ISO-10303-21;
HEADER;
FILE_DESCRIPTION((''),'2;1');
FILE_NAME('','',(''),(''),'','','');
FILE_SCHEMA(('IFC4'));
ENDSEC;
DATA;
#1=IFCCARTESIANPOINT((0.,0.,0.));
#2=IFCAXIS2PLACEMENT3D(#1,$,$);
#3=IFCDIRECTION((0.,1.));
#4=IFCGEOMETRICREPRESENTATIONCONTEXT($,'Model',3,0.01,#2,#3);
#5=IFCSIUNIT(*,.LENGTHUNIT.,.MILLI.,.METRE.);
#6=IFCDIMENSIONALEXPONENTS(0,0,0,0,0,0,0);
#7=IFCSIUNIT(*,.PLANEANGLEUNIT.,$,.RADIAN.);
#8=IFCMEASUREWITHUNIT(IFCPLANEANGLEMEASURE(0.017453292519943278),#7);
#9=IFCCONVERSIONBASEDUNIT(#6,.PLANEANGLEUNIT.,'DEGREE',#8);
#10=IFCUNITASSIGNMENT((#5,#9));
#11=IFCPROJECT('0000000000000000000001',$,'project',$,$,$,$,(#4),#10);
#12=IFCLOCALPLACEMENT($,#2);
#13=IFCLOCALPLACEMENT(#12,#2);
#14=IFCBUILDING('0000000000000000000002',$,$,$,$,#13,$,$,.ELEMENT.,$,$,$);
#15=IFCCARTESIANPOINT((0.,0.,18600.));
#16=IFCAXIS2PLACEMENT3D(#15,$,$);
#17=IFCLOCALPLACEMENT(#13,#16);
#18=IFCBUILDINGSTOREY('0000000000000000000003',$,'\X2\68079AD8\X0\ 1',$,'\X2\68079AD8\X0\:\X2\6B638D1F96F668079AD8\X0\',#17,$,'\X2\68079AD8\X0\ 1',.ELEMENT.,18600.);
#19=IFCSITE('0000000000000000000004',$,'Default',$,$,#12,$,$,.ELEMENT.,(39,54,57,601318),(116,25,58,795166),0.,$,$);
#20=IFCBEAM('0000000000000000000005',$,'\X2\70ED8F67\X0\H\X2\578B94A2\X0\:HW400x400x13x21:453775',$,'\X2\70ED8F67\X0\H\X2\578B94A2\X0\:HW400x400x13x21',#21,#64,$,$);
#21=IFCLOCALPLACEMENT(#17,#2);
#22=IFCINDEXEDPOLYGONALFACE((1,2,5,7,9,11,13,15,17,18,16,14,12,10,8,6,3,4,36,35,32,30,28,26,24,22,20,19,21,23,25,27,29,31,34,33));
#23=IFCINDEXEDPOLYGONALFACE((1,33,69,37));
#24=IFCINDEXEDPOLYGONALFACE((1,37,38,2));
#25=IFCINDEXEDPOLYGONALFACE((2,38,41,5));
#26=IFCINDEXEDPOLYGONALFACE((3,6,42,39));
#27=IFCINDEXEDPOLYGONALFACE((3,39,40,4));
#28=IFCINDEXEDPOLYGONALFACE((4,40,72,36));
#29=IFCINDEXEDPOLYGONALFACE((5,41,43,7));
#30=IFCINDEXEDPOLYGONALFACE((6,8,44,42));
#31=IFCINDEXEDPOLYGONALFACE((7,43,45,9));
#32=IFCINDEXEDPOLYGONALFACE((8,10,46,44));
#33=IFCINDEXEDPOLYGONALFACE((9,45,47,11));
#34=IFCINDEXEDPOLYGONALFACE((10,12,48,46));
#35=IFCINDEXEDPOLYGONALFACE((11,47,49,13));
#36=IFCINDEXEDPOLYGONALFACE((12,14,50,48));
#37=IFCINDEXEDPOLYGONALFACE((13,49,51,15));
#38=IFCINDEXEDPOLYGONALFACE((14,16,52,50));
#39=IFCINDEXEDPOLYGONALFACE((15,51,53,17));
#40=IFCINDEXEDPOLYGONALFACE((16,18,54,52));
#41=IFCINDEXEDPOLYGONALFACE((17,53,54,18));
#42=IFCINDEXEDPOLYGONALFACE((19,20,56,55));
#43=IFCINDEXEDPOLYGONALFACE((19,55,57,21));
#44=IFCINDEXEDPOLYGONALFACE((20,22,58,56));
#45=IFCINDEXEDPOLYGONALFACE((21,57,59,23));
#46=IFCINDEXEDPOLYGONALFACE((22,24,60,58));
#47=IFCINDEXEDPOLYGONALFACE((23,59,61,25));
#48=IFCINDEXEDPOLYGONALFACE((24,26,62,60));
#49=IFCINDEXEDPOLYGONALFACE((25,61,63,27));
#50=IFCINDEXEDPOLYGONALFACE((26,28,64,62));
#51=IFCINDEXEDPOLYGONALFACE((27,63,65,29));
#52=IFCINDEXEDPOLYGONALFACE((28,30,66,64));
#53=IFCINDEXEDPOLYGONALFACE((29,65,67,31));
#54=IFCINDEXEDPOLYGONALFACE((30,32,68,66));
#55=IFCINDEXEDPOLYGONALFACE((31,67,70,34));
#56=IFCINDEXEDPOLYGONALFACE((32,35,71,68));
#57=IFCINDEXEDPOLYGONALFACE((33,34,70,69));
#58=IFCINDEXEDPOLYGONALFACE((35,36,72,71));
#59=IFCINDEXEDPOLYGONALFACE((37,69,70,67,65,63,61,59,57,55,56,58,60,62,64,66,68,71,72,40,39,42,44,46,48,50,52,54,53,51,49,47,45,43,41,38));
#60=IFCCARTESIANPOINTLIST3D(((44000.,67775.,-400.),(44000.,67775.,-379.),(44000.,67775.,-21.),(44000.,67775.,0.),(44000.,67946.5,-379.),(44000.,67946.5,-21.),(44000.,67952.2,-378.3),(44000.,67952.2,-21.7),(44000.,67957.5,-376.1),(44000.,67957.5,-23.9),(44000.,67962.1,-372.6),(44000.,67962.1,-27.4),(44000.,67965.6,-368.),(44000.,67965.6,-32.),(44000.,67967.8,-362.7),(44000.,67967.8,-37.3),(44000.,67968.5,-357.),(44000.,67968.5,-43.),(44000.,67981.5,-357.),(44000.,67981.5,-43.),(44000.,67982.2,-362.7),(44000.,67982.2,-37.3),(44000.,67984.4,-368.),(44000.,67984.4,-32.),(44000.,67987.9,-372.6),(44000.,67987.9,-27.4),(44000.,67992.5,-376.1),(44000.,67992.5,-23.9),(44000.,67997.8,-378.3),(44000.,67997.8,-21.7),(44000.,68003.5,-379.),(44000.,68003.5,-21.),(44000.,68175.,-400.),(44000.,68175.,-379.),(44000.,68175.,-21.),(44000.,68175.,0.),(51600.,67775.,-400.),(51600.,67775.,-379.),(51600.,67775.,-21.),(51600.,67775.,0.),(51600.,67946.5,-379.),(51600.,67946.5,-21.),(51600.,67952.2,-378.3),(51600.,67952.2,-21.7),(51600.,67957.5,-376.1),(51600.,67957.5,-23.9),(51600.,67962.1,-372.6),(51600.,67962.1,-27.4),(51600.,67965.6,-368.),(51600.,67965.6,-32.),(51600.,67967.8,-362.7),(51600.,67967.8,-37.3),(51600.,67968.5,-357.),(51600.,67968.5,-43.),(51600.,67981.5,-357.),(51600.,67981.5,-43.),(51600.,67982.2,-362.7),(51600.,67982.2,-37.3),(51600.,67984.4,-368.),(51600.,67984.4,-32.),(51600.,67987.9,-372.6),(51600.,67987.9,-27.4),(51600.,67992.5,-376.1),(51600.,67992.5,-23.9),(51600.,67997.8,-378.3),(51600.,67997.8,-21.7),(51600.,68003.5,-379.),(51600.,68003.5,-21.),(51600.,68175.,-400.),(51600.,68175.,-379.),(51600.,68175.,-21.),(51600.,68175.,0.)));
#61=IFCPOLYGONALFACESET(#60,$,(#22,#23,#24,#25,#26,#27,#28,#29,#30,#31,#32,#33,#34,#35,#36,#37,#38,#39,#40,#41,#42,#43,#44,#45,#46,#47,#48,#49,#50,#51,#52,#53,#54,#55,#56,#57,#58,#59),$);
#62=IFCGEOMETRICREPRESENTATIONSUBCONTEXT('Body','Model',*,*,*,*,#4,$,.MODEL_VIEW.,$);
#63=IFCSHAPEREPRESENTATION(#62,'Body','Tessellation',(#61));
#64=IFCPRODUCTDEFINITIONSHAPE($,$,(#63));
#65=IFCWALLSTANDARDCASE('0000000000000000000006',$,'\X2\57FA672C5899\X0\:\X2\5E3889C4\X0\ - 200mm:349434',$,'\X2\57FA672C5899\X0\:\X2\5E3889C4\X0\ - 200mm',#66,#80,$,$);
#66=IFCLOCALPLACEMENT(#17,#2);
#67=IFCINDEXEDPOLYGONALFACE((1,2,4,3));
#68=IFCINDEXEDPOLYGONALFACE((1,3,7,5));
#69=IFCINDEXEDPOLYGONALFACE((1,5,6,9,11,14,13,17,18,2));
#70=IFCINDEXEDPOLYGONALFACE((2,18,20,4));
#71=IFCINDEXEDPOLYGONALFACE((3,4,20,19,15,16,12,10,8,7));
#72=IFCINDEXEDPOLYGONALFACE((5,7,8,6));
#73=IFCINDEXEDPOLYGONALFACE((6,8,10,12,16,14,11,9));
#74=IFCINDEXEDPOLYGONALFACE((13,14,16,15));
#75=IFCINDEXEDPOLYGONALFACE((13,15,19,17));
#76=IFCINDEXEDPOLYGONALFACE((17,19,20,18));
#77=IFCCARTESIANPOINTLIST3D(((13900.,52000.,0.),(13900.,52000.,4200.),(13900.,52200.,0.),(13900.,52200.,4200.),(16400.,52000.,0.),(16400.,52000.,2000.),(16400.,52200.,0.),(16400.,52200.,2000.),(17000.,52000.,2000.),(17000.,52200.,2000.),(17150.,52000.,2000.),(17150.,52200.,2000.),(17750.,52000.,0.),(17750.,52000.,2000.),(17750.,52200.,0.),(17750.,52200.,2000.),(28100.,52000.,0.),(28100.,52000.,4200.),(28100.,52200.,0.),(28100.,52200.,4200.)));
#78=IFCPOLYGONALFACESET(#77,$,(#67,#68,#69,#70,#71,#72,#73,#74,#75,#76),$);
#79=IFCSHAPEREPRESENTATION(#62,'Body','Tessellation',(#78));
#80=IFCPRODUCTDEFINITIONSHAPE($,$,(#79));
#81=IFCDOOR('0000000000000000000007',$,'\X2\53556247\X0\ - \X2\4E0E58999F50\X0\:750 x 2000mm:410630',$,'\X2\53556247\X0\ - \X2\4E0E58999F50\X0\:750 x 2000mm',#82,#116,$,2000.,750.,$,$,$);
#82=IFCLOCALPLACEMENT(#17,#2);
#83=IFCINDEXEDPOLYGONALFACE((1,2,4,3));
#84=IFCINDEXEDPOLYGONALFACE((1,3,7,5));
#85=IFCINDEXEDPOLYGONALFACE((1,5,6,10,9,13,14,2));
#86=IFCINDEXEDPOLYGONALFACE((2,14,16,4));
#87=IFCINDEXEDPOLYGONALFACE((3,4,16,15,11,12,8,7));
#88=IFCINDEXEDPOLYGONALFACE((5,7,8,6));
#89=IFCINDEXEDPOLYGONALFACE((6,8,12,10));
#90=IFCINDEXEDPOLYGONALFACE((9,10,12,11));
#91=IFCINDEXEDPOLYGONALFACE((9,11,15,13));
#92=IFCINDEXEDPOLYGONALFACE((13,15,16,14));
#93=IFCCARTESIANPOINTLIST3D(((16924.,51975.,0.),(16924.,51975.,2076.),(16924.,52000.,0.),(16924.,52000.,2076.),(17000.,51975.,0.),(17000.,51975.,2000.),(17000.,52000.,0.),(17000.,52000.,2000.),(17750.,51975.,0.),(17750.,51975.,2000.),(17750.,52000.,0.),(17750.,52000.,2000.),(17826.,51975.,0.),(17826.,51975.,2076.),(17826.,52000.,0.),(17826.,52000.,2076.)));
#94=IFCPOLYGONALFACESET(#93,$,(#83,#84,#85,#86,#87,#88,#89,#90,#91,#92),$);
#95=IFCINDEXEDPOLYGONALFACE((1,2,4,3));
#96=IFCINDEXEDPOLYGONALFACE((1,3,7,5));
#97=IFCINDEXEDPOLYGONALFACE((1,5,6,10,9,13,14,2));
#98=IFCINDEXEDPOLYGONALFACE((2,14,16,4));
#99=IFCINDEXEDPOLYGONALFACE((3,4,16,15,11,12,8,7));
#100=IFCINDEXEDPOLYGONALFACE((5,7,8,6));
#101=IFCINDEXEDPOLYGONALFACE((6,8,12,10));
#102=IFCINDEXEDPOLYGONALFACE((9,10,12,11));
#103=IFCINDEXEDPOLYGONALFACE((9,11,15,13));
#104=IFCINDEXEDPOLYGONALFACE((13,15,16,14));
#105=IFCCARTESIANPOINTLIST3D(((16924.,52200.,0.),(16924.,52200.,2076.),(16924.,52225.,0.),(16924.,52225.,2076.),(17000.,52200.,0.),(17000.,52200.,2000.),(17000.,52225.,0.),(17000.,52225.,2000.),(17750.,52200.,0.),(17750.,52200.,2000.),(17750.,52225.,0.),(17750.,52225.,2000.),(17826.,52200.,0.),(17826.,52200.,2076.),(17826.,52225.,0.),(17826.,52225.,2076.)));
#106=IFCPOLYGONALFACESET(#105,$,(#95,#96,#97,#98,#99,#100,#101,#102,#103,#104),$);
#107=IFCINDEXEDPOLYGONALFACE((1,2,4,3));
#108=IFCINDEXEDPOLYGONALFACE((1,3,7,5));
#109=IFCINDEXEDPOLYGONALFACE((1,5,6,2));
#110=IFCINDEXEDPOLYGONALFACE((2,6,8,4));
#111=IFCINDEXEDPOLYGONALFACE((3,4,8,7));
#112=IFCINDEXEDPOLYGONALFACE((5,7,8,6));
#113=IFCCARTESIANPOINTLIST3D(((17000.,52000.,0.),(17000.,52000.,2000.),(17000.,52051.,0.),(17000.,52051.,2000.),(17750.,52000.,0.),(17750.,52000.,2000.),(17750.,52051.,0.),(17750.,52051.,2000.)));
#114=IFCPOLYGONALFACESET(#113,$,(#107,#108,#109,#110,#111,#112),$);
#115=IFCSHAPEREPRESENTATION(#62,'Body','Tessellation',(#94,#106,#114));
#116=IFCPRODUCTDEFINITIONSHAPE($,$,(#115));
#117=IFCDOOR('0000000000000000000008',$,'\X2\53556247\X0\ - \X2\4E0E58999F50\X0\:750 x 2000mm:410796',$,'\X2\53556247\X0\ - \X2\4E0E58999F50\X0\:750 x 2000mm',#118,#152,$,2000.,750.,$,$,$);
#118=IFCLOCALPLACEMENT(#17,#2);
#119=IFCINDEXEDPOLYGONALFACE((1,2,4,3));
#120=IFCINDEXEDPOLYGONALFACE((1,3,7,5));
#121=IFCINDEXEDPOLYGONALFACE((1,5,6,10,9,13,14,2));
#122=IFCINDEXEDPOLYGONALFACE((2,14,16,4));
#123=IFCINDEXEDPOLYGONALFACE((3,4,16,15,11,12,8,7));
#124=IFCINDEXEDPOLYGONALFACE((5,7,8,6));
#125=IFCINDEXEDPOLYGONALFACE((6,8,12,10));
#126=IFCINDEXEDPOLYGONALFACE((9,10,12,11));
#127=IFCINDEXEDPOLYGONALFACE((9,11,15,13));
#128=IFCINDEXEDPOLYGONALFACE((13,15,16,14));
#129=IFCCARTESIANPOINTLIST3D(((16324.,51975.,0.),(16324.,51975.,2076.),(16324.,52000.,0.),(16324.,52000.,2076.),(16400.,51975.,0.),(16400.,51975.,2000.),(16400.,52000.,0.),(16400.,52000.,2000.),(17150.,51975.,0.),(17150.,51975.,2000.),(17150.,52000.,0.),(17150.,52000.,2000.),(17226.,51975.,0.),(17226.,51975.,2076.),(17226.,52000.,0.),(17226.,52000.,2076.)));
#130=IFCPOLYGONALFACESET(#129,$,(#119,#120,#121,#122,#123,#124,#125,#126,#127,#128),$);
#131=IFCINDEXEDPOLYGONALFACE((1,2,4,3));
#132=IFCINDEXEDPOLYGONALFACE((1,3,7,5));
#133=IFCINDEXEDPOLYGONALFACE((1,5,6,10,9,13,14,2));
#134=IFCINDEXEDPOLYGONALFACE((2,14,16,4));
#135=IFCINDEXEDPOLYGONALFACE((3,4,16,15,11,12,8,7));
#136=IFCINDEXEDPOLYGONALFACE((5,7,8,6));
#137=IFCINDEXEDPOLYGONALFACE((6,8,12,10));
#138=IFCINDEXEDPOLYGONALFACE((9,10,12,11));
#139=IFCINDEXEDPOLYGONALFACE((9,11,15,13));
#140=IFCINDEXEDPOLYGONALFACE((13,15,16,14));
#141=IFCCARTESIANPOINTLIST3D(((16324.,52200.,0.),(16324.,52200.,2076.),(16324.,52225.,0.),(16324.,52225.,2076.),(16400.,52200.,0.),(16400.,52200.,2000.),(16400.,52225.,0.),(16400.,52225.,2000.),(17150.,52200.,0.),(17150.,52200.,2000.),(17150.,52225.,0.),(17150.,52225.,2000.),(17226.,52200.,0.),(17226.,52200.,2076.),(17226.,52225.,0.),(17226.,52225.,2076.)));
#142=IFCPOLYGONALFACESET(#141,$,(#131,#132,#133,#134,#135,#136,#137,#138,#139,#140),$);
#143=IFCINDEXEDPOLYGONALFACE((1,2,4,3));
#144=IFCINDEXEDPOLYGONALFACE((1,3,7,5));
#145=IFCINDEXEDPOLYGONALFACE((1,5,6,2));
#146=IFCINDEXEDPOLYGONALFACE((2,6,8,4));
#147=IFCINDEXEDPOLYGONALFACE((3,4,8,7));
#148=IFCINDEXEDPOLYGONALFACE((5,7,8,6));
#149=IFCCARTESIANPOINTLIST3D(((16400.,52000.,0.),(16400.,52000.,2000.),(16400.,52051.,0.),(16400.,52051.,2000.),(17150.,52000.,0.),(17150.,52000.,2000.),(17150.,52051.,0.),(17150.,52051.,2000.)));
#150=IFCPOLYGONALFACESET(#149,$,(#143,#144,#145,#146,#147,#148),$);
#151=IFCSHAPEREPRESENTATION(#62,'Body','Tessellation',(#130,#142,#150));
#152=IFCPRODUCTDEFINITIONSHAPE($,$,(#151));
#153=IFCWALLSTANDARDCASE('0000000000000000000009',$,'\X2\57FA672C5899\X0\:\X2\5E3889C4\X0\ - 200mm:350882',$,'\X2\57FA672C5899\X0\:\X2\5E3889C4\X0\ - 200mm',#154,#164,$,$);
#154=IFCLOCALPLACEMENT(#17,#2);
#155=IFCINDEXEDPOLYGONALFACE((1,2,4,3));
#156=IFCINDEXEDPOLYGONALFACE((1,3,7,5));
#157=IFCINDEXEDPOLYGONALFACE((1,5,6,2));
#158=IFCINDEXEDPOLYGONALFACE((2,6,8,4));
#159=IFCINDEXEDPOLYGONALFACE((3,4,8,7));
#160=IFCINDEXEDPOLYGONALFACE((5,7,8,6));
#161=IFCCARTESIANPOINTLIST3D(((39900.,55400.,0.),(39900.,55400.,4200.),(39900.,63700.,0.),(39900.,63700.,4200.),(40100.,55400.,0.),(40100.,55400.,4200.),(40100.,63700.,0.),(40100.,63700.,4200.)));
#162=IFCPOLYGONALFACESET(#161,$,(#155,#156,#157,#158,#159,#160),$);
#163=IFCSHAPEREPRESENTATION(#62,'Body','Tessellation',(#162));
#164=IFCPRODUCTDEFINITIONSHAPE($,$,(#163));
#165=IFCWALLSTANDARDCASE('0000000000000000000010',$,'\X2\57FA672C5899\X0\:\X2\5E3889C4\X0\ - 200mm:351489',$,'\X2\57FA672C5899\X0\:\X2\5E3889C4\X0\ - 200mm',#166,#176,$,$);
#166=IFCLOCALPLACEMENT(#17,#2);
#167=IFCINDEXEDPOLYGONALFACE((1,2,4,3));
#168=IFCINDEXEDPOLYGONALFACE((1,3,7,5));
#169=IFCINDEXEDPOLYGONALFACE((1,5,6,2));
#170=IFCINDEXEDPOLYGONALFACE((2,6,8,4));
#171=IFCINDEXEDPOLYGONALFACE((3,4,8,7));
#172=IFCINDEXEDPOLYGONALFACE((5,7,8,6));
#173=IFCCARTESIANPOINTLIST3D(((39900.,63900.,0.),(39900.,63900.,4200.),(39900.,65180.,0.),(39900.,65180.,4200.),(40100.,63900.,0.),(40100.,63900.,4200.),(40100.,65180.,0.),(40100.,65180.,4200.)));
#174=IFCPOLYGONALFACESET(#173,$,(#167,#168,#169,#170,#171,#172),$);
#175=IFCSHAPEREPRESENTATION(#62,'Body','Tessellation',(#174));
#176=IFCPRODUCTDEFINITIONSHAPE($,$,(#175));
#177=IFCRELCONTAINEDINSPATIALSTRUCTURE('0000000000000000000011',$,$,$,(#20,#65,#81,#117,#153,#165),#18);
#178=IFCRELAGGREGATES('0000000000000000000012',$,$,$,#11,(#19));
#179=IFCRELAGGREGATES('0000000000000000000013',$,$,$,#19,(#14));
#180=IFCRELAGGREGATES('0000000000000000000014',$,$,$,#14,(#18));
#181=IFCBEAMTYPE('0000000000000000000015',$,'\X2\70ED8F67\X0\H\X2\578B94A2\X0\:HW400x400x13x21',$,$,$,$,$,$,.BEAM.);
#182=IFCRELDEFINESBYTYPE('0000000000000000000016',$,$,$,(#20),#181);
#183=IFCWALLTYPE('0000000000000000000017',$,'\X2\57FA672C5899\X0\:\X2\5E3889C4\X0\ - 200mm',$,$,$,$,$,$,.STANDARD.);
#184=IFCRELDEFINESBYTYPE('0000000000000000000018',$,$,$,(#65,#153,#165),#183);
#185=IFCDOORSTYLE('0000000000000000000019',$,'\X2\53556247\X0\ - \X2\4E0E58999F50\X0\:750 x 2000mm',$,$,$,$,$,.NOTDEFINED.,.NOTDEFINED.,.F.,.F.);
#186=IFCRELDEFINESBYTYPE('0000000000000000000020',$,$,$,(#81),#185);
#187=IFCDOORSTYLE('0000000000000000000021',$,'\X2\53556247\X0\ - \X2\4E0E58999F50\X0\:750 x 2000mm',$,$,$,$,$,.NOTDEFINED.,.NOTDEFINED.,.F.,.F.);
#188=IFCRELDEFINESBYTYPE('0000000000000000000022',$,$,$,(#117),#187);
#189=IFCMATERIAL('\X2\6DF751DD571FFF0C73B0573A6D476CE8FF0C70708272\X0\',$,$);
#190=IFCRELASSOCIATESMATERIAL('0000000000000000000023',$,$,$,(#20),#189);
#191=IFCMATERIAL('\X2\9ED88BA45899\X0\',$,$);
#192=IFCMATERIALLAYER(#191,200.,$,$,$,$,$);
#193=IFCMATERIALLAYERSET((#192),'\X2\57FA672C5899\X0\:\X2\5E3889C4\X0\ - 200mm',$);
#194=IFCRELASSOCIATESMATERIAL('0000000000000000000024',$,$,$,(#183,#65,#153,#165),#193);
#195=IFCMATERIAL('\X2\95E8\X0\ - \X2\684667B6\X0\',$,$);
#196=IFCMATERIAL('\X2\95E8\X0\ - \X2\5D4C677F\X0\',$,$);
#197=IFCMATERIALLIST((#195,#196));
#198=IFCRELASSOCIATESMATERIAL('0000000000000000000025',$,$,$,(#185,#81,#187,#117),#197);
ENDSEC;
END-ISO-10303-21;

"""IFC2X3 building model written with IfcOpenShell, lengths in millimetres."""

from ifc_helpers import new_model, entity, si_unit, converted_unit, direction, frame, frame_2d, origin, place, context, subcontext, project, spatial, polyline, rectangle, i_section, outline, extrude, source, transform, mapped, material, material_list, layer, layer_set, layer_usage, type_object, type_shapes, element, fill, save


model = new_model("IFC2X3")

# Units and contexts
model_context = context("Model", 3, precision=0.01, world=origin(), true_north=direction((0.0, 1.0)))
body_context = subcontext(model_context, "Body", "Model", "MODEL_VIEW")
ifc_project = project(units=[si_unit("LENGTHUNIT", "METRE", prefix="MILLI"), converted_unit("PLANEANGLEUNIT", "DEGREE", entity("IfcPlaneAngleMeasure", 0.017453292519943278), si_unit("PLANEANGLEUNIT", "RADIAN"), dimensions=[0, 0, 0, 0, 0, 0, 0])], contexts=[model_context])

# Site, building, storey
site_placement = place(None, origin())
site = spatial("IfcSite", under=ifc_project, at=site_placement, Name="Default", CompositionType="ELEMENT", RefLatitude=(39, 54, 57, 601318), RefLongitude=(116, 25, 58, 795166), RefElevation=0.0)
building_placement = place(site_placement, origin())
building = spatial("IfcBuilding", under=site, at=building_placement, CompositionType="ELEMENT")
storey_placement = place(building_placement, frame((0.0, 0.0, 18600.0)))
storey = spatial("IfcBuildingStorey", under=building, at=storey_placement, Name="标高 1", ObjectType="标高:正负零标高", LongName="标高 1", CompositionType="ELEMENT", Elevation=18600.0)

# Beam
ifc_material_1 = material(Name="混凝土，现场浇注，灰色")
beam_type = type_object("IfcBeamType", Name="热轧H型钢:HW400x400x13x21", PredefinedType="BEAM")
beam_placement = place(storey_placement, frame((44000.0, 67975.0, 0.0)))
element("IfcBeam", 1, at=beam_placement, inside=storey, type_object=beam_type, material=ifc_material_1, Name="热轧H型钢:HW400x400x13x21:453775", ObjectType="热轧H型钢:HW400x400x13x21", context=body_context, shape_type="SweptSolid", body=[
    extrude(i_section(OverallWidth=400.0, OverallDepth=400.0, WebThickness=13.0, FlangeThickness=21.0, FilletRadius=22.0, at=frame_2d((0.0, 0.0), x_axis=(0.0, 1.0))), frame((0.0, 0.0, -200.0), z_axis=(1.0, 0.0, 0.0), x_axis=(0.0, 0.0, -1.0)), (0.0, 0.0, 1.0), 7600.0),
])

# Wall, openings, doors
ifc_material_2 = material(Name="默认墙")
ifc_layer = layer(ifc_material_2, 200.0)
ifc_layer_set = layer_set([ifc_layer], Name="基本墙:常规 - 200mm")
ifc_layer_usage_1 = layer_usage(ifc_layer_set, "AXIS2", "NEGATIVE", 100.0)
wall_type = type_object("IfcWallType", Name="基本墙:常规 - 200mm", PredefinedType="STANDARD", material=ifc_layer_set)
wall_1_placement = place(storey_placement, frame((28100.0, 52100.0, 0.0), z_axis=(0.0, 0.0, 1.0), x_axis=(-1.0, 0.0, 0.0)))
wall_1 = element("IfcWallStandardCase", 2, at=wall_1_placement, inside=storey, type_object=wall_type, material=ifc_layer_usage_1, Name="基本墙:常规 - 200mm:349434", ObjectType="基本墙:常规 - 200mm", context=body_context, shape_type="SweptSolid", body=[
    extrude(rectangle(XDim=14200.0, YDim=200.0, at=frame_2d((7100.0, 0.0), x_axis=(-1.0, 0.0))), origin(), (0.0, 0.0, 1.0), 4200.0),
])
opening_1_placement = place(wall_1_placement, frame((10350.0, -100.0, 0.0)))
opening_1 = element("IfcOpeningElement", 3, at=opening_1_placement, cuts=wall_1, ObjectType="Opening", context=body_context, shape_type="SweptSolid", body=[
    extrude(rectangle(XDim=750.0, YDim=2000.0, at=frame_2d((1000.0, 375.0), x_axis=(0.0, -1.0))), frame((0.0, 0.0, 0.0), z_axis=(0.0, 1.0, 0.0), x_axis=(0.0, 0.0, 1.0)), (0.0, 0.0, 1.0), 200.0),
])
opening_2_placement = place(wall_1_placement, frame((10950.0, -100.0, 0.0)))
opening_2 = element("IfcOpeningElement", 4, at=opening_2_placement, cuts=wall_1, ObjectType="Opening", context=body_context, shape_type="SweptSolid", body=[
    extrude(rectangle(XDim=750.0, YDim=2000.0, at=frame_2d((1000.0, 375.0), x_axis=(0.0, 1.0))), frame((0.0, 0.0, 0.0), z_axis=(0.0, 1.0, 0.0), x_axis=(0.0, 0.0, 1.0)), (0.0, 0.0, 1.0), 200.0),
])
ifc_material_3 = material(Name="门 - 框架")
ifc_material_4 = material(Name="门 - 嵌板")
ifc_material_list = material_list([ifc_material_3, ifc_material_4])
door_style_1 = type_object("IfcDoorStyle", Name="单扇 - 与墙齐:750 x 2000mm", ConstructionType="NOTDEFINED", OperationType="NOTDEFINED", ParameterTakesPrecedence=False, Sizeable=False, material=ifc_material_list)
shared_shape_1 = source(origin(), body_context, "Body", "SweptSolid", [
    extrude(outline(polyline([(-451.0, -1057.0), (451.0, -1057.0), (451.0, 1019.0), (375.0, 1019.0), (375.0, -981.0), (-375.0, -981.0), (-375.0, 1019.0), (-451.0, 1019.0), (-451.0, -1057.0)])), frame((375.0, 225.0, 1019.0), z_axis=(0.0, -1.0, 0.0), x_axis=(-1.0, 0.0, 0.0)), (0.0, 0.0, 1.0), 25.0),
    extrude(outline(polyline([(-1057.0, -451.0), (1019.0, -451.0), (1019.0, -375.0), (-981.0, -375.0), (-981.0, 375.0), (1019.0, 375.0), (1019.0, 451.0), (-1057.0, 451.0), (-1057.0, -451.0)])), frame((375.0, 0.0, 1019.0), z_axis=(0.0, -1.0, 0.0), x_axis=(0.0, 0.0, -1.0)), (0.0, 0.0, 1.0), 25.0),
    extrude(rectangle(XDim=750.0, YDim=51.0, at=frame_2d((0.0, 0.0), x_axis=(1.0, 0.0))), frame((375.0, 174.5, 0.0)), (0.0, 0.0, 1.0), 2000.0),
])
type_shapes(door_style_1, [shared_shape_1])
door_1_placement = place(opening_1_placement, origin())
door_1 = element("IfcDoor", 5, at=door_1_placement, inside=storey, type_object=door_style_1, material=ifc_material_list, Name="单扇 - 与墙齐:750 x 2000mm:410630", ObjectType="单扇 - 与墙齐:750 x 2000mm", OverallHeight=2000.0, OverallWidth=750.0, context=body_context, shape_type="MappedRepresentation", body=[
    mapped(shared_shape_1, transform((0.0, 0.0, 0.0), scale=1.0)),
])
fill(opening_1, door_1)
door_style_2 = type_object("IfcDoorStyle", Name="单扇 - 与墙齐:750 x 2000mm", ConstructionType="NOTDEFINED", OperationType="NOTDEFINED", ParameterTakesPrecedence=False, Sizeable=False, material=ifc_material_list)
shared_shape_2 = source(origin(), body_context, "Body", "SweptSolid", [
    extrude(outline(polyline([(-451.0, -1057.0), (451.0, -1057.0), (451.0, 1019.0), (375.0, 1019.0), (375.0, -981.0), (-375.0, -981.0), (-375.0, 1019.0), (-451.0, 1019.0), (-451.0, -1057.0)])), frame((375.0, 200.0, 1019.0), z_axis=(0.0, 1.0, 0.0), x_axis=(1.0, 0.0, 0.0)), (0.0, 0.0, 1.0), 25.0),
    extrude(outline(polyline([(-1057.0, -451.0), (1019.0, -451.0), (1019.0, -375.0), (-981.0, -375.0), (-981.0, 375.0), (1019.0, 375.0), (1019.0, 451.0), (-1057.0, 451.0), (-1057.0, -451.0)])), frame((375.0, -25.0, 1019.0), z_axis=(0.0, 1.0, 0.0), x_axis=(0.0, 0.0, -1.0)), (0.0, 0.0, 1.0), 25.0),
    extrude(rectangle(XDim=51.0, YDim=750.0, at=frame_2d((0.0, 0.0), x_axis=(1.0, 0.0))), frame((375.0, 174.5, 0.0), z_axis=(0.0, 0.0, 1.0), x_axis=(0.0, 1.0, 0.0)), (0.0, 0.0, 1.0), 2000.0),
])
type_shapes(door_style_2, [shared_shape_2])
door_2_placement = place(opening_2_placement, origin())
door_2 = element("IfcDoor", 6, at=door_2_placement, inside=storey, type_object=door_style_2, material=ifc_material_list, Name="单扇 - 与墙齐:750 x 2000mm:410796", ObjectType="单扇 - 与墙齐:750 x 2000mm", OverallHeight=2000.0, OverallWidth=750.0, context=body_context, shape_type="MappedRepresentation", body=[
    mapped(shared_shape_2, transform((0.0, 0.0, 0.0), scale=1.0)),
])
fill(opening_2, door_2)

# Walls
ifc_layer_usage_2 = layer_usage(ifc_layer_set, "AXIS2", "NEGATIVE", 100.0)
wall_2_placement = place(storey_placement, frame((40000.0, 55400.0, 0.0), z_axis=(0.0, 0.0, 1.0), x_axis=(0.0, 1.0, 0.0)))
element("IfcWallStandardCase", 7, at=wall_2_placement, inside=storey, type_object=wall_type, material=ifc_layer_usage_2, Name="基本墙:常规 - 200mm:350882", ObjectType="基本墙:常规 - 200mm", context=body_context, shape_type="SweptSolid", body=[
    extrude(rectangle(XDim=8300.0, YDim=200.0, at=frame_2d((4150.0, 0.0), x_axis=(-1.0, 0.0))), origin(), (0.0, 0.0, 1.0), 4200.0),
])
ifc_layer_usage_3 = layer_usage(ifc_layer_set, "AXIS2", "NEGATIVE", 100.0)
wall_3_placement = place(storey_placement, frame((40000.0, 63900.0, 0.0), z_axis=(0.0, 0.0, 1.0), x_axis=(0.0, 1.0, 0.0)))
element("IfcWallStandardCase", 8, at=wall_3_placement, inside=storey, type_object=wall_type, material=ifc_layer_usage_3, Name="基本墙:常规 - 200mm:351489", ObjectType="基本墙:常规 - 200mm", context=body_context, shape_type="SweptSolid", body=[
    extrude(rectangle(XDim=1280.0, YDim=200.0, at=frame_2d((640.0, 0.0), x_axis=(-1.0, 0.0))), origin(), (0.0, 0.0, 1.0), 4200.0),
])

save(model, "model.ifc")
